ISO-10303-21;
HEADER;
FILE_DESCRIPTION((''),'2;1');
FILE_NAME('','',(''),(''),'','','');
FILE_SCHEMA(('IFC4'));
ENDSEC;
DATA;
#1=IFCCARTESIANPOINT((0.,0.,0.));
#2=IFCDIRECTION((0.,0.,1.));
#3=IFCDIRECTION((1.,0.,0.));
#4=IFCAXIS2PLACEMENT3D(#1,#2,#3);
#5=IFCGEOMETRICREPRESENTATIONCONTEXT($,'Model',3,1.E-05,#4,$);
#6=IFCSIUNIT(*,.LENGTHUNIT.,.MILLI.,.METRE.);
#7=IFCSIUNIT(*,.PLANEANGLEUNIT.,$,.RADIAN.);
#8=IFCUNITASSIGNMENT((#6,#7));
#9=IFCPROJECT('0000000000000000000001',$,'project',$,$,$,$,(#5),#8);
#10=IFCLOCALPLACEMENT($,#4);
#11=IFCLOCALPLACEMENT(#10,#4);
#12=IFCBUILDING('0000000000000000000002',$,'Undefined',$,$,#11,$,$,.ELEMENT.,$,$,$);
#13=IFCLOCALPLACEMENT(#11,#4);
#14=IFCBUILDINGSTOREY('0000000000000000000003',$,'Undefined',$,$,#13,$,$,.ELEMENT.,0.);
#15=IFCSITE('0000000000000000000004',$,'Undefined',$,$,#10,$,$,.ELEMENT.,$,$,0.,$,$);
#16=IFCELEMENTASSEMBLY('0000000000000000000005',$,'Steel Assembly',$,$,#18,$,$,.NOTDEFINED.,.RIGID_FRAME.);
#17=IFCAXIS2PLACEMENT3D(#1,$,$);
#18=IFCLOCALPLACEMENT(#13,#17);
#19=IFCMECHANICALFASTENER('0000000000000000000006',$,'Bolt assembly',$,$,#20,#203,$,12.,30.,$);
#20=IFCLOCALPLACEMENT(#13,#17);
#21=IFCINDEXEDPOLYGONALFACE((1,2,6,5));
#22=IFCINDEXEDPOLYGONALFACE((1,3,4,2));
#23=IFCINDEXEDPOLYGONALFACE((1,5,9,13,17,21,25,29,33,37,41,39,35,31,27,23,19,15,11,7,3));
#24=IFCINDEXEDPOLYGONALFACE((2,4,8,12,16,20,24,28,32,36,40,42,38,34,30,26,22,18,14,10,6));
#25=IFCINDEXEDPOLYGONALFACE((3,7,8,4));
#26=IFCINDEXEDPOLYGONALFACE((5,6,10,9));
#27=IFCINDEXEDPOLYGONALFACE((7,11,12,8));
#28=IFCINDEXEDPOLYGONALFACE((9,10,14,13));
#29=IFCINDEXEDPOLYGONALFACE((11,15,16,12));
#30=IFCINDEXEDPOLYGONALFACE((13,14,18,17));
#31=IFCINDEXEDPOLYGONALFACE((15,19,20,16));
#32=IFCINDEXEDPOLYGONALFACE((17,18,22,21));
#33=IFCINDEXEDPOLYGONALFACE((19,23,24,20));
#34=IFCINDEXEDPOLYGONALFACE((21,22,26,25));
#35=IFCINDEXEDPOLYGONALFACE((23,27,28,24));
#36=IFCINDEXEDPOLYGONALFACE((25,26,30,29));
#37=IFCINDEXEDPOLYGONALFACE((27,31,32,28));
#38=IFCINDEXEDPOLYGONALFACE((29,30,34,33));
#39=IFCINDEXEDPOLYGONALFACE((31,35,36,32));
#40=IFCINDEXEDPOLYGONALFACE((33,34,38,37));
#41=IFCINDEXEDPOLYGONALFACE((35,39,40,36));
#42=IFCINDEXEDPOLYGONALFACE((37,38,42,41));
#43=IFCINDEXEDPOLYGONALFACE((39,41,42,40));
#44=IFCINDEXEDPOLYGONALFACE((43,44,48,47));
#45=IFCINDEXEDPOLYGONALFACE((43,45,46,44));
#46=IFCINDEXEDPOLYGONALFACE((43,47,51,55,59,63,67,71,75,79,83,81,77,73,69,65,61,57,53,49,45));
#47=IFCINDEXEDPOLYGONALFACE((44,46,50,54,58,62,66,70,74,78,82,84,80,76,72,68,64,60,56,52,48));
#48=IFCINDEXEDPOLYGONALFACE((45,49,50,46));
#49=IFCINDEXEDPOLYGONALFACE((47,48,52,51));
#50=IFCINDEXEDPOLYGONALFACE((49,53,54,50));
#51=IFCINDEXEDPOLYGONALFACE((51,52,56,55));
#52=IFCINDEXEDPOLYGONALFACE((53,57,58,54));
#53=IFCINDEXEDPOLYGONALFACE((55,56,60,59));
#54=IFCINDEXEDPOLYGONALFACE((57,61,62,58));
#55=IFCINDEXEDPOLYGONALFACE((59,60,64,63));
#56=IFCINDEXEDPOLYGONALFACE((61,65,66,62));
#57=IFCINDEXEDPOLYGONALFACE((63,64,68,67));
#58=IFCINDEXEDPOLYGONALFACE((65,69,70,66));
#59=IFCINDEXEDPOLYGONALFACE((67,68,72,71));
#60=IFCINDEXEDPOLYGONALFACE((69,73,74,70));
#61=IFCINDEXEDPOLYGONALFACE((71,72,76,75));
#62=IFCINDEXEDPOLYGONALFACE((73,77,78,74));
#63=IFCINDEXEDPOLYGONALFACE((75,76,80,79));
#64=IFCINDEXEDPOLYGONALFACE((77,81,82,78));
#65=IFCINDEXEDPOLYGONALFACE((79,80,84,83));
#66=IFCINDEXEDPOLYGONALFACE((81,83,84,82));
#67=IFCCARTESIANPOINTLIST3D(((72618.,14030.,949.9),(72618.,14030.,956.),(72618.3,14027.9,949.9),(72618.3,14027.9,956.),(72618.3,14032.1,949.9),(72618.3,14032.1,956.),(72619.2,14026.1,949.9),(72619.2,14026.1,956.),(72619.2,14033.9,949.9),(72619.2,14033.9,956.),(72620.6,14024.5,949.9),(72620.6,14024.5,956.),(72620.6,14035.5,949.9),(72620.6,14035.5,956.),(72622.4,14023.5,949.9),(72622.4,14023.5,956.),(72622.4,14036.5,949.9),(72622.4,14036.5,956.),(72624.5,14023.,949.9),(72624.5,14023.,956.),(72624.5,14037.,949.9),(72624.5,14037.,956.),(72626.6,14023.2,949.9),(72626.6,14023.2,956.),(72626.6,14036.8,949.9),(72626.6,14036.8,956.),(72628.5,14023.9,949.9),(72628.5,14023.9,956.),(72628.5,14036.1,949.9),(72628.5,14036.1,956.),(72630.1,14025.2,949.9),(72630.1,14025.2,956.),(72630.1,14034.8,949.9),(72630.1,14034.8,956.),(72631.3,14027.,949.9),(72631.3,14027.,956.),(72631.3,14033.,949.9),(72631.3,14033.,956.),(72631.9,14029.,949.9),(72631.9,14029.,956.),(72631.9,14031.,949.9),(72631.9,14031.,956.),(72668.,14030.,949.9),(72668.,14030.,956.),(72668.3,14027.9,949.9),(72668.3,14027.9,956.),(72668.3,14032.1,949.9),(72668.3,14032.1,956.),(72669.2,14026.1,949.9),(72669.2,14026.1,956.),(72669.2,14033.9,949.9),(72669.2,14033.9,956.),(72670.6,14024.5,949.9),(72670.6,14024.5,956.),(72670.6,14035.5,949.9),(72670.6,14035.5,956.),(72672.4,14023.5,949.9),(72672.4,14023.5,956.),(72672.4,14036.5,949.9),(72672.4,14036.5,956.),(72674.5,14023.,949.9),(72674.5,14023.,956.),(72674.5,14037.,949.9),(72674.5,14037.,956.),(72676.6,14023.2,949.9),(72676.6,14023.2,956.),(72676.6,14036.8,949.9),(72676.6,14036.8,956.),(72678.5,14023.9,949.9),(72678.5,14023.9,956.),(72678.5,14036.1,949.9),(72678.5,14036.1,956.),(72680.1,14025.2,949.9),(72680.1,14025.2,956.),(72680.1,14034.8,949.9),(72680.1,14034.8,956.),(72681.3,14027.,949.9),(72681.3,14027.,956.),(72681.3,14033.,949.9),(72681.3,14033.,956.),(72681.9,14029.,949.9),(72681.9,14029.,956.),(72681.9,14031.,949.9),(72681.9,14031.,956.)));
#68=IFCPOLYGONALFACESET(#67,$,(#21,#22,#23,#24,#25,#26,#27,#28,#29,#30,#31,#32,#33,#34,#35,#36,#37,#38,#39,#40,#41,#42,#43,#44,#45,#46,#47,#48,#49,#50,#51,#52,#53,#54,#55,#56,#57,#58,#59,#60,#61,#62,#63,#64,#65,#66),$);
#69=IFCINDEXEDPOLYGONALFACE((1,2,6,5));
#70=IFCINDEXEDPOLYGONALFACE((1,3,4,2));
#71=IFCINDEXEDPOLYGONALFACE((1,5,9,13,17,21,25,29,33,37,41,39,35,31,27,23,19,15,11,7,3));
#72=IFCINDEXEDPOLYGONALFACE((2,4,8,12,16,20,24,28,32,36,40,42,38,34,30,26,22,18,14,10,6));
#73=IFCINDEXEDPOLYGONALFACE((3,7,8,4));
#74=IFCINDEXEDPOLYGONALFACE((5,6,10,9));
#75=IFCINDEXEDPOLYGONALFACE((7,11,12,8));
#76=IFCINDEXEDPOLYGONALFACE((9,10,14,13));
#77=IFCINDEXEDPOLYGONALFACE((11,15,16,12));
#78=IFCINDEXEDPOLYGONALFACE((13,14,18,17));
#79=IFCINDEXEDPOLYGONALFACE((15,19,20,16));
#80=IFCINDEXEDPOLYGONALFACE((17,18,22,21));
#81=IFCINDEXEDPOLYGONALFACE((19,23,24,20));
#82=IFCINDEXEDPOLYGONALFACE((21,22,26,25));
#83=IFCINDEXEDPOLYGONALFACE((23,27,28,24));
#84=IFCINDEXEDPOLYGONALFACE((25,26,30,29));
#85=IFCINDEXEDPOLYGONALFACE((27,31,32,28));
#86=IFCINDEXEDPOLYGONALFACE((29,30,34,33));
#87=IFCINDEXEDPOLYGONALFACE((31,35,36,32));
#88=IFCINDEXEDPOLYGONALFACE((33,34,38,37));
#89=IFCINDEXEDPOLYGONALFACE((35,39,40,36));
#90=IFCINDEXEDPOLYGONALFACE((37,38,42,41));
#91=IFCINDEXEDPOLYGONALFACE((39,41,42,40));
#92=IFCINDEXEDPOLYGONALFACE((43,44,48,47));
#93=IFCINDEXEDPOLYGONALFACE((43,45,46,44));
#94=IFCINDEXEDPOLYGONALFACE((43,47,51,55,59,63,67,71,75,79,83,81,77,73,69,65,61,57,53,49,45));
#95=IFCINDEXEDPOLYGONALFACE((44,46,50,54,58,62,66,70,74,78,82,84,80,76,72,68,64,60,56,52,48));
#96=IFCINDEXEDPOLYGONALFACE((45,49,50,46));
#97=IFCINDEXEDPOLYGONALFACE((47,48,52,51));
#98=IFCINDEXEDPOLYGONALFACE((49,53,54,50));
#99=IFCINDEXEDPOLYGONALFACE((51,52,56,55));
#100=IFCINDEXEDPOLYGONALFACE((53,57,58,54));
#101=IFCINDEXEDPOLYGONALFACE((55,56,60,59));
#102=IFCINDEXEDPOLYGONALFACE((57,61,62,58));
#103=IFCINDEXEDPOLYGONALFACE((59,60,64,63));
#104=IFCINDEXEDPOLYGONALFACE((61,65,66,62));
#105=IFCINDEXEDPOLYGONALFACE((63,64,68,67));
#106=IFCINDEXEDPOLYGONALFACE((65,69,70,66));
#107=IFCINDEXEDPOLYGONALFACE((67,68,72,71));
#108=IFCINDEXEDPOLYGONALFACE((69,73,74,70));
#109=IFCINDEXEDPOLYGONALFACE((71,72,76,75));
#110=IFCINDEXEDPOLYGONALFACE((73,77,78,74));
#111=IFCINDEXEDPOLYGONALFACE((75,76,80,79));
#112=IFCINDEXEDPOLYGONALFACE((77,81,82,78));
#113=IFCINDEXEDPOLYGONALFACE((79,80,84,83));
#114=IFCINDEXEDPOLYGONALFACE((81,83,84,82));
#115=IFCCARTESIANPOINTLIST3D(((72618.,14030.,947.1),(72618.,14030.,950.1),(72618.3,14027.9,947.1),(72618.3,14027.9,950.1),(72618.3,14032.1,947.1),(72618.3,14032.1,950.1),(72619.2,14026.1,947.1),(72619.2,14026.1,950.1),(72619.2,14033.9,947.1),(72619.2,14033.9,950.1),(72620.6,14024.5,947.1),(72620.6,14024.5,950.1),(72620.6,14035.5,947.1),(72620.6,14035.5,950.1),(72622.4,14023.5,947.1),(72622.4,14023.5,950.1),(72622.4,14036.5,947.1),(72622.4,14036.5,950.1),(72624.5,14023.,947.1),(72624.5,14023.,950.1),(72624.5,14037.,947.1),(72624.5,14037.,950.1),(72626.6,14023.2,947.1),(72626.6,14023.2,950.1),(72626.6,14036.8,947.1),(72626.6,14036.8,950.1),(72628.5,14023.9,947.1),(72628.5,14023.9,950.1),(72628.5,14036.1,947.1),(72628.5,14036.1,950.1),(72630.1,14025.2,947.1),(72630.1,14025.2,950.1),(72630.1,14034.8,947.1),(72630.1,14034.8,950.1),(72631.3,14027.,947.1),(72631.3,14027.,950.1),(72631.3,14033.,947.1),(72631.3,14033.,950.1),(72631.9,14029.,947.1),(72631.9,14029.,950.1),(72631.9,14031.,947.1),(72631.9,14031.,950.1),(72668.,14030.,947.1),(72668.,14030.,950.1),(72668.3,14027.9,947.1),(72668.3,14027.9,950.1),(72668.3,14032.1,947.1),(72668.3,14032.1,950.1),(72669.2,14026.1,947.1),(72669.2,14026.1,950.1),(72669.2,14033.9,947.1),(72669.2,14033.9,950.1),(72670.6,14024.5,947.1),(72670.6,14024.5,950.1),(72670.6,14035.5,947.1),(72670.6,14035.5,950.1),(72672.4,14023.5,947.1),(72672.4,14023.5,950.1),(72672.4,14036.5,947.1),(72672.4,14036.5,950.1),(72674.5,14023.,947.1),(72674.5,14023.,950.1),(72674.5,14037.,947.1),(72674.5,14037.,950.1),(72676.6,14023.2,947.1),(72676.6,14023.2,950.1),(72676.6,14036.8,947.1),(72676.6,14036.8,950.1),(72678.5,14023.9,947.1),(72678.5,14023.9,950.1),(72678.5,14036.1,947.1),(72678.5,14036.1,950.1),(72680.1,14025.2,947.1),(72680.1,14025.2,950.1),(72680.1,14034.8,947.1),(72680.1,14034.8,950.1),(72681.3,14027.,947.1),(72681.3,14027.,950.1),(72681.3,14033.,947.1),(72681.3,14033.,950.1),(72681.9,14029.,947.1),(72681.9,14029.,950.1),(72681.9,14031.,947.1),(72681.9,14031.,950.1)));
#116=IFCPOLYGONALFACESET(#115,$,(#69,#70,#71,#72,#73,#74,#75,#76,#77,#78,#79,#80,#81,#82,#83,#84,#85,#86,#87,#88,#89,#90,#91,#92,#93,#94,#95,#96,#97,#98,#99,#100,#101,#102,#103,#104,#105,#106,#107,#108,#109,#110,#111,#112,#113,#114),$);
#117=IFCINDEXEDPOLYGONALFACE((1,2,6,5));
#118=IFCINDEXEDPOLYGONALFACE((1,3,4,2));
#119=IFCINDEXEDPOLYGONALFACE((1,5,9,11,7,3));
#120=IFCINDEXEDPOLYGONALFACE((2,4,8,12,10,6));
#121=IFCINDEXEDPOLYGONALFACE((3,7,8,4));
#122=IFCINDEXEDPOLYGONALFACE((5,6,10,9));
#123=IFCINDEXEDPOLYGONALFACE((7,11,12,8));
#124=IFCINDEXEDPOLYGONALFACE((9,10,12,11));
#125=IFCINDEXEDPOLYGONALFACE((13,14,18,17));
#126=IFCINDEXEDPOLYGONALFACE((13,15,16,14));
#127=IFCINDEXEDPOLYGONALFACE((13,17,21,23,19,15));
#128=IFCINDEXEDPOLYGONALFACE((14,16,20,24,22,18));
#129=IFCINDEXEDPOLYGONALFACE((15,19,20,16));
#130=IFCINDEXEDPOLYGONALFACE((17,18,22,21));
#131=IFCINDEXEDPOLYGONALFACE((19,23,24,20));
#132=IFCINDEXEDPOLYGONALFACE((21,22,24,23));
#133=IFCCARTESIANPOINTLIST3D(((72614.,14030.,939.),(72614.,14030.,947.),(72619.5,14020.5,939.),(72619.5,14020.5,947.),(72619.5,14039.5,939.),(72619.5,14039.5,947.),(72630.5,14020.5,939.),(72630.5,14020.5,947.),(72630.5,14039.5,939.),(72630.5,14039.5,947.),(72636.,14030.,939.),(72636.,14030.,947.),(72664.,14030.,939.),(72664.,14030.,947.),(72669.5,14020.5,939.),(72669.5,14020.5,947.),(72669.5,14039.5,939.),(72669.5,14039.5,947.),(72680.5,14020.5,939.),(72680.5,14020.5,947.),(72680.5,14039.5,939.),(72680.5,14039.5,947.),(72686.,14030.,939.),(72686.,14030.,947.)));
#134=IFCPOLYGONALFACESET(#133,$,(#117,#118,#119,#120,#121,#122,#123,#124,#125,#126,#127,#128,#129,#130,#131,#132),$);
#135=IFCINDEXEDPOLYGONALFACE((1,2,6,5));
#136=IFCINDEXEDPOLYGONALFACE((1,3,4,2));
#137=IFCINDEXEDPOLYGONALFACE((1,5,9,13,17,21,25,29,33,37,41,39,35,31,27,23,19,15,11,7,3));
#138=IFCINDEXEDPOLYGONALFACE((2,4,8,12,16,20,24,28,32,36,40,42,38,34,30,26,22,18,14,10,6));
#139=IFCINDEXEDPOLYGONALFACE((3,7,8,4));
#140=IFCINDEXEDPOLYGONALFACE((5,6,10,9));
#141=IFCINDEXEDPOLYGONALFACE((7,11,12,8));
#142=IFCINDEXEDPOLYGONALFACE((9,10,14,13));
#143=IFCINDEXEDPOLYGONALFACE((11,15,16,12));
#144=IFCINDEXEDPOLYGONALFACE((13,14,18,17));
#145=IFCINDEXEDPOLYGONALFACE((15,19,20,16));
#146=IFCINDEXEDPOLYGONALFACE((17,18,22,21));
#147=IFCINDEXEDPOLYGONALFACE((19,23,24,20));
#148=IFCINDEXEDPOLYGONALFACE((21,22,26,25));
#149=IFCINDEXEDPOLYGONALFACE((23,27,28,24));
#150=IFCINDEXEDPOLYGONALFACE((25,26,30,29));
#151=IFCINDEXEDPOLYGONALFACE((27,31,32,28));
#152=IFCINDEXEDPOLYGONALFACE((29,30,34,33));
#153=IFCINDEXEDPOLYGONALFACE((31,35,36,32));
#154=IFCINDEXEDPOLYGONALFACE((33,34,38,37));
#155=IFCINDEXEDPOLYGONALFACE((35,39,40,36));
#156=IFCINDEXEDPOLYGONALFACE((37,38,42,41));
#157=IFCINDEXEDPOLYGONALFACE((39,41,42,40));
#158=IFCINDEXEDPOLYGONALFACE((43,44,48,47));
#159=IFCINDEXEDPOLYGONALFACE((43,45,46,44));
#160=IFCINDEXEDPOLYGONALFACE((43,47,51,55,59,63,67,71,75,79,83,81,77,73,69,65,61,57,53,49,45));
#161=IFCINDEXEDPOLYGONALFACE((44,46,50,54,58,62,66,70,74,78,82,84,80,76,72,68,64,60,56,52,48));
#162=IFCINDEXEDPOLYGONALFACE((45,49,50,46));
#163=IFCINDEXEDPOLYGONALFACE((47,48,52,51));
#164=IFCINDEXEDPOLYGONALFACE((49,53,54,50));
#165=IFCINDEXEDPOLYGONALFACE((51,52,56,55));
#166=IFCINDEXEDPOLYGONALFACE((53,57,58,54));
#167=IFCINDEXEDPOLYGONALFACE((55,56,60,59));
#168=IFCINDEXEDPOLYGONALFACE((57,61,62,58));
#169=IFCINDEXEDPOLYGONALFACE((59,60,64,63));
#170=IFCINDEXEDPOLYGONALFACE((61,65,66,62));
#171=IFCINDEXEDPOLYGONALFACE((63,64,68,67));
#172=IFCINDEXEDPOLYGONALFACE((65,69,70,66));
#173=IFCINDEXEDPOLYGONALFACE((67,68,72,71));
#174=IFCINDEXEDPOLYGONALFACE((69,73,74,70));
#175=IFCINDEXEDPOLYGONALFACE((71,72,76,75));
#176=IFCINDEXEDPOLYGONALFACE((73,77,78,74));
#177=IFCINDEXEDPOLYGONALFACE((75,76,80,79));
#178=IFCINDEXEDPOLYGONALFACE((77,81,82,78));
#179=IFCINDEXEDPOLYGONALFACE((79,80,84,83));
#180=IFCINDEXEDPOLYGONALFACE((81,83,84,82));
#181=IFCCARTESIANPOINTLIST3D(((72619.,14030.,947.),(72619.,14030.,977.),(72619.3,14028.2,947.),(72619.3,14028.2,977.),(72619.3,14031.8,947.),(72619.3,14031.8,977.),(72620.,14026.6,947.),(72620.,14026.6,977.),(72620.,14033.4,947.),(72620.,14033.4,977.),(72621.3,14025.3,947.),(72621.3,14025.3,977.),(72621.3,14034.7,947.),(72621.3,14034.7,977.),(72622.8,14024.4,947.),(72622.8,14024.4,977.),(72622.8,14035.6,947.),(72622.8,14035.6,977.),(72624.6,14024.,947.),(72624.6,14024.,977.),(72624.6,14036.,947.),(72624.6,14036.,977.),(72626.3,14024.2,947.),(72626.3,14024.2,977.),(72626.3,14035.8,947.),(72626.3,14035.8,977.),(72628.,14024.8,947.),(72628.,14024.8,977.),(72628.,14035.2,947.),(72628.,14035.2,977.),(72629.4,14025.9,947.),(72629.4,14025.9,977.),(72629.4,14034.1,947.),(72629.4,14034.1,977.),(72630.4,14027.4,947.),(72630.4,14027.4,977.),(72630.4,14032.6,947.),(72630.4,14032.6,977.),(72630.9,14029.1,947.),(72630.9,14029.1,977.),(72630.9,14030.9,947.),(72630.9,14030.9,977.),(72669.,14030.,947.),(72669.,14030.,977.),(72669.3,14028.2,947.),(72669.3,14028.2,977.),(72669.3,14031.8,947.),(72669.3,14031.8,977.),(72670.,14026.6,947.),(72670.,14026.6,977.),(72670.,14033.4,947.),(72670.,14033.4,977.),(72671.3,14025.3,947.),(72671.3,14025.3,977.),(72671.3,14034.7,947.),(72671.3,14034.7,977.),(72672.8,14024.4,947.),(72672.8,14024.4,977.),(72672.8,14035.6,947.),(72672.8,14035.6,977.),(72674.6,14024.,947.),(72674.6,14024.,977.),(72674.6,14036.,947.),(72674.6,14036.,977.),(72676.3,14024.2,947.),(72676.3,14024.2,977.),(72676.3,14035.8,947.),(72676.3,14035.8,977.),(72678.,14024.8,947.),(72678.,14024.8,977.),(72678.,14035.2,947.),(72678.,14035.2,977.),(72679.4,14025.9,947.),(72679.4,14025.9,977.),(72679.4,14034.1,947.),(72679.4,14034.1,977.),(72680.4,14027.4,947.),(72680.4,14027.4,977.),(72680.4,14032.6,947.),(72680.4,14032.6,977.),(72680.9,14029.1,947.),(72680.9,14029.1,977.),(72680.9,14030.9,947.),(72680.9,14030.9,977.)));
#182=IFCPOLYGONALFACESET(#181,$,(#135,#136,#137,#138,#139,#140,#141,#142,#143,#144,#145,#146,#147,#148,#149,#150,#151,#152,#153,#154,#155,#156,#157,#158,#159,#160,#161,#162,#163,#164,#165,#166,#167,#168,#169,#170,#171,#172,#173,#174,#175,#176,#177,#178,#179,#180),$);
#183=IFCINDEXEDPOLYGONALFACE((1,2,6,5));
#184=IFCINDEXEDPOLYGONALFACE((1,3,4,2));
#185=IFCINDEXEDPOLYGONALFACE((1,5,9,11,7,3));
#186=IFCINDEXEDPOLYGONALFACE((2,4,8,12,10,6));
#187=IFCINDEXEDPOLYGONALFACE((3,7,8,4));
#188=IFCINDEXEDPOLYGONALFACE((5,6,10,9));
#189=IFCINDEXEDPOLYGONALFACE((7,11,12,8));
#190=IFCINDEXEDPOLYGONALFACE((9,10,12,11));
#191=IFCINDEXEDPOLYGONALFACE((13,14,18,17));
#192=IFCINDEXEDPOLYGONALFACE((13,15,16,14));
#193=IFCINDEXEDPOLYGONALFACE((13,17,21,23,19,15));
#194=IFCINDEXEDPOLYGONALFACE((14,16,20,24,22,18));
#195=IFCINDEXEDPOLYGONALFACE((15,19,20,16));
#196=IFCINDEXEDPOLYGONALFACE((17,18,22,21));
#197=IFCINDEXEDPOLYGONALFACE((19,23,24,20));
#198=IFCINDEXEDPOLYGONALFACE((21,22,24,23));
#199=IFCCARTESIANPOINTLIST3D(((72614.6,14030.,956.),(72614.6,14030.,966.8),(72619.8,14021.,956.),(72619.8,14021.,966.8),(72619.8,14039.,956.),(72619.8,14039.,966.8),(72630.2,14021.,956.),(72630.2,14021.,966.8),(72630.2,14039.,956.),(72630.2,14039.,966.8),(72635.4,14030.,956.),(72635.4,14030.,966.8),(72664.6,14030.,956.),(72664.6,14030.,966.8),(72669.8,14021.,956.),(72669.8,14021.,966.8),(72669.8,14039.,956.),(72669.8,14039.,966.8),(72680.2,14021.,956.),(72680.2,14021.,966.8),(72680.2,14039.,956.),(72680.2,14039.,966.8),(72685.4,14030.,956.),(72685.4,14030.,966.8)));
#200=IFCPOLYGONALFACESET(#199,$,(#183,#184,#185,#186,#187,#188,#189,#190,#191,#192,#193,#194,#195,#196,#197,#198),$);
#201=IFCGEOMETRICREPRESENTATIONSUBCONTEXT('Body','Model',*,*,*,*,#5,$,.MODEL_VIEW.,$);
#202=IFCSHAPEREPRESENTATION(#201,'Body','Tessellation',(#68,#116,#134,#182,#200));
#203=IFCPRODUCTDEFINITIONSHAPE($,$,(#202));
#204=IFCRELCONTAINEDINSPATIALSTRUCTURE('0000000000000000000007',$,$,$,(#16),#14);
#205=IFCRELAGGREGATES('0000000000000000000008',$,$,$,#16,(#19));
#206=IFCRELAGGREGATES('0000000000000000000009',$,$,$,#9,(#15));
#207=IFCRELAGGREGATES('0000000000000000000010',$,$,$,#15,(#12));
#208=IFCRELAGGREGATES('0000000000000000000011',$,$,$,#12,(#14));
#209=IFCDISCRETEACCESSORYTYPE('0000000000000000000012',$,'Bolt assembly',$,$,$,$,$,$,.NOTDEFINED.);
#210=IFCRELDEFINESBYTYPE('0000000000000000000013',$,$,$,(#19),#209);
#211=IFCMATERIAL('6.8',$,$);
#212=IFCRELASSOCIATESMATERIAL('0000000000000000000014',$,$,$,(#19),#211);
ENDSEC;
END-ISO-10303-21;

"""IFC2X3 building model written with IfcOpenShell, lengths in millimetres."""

from ifc_helpers import new_model, si_unit, frame, origin_with_axes, origin_2d_with_axis, place, context, subcontext, project, spatial, polyline, circle, outline, extrude, source, transform, mapped, material, type_object, element, aggregate, save


model = new_model("IFC2X3")

# Units and contexts
model_context = context("Model", 3, precision=1e-05, world=origin_with_axes())
body_context = subcontext(model_context, "Body", "Model", "MODEL_VIEW")
ifc_project = project(units=[si_unit("LENGTHUNIT", "METRE", prefix="MILLI"), si_unit("PLANEANGLEUNIT", "RADIAN")], contexts=[model_context])

# Site, building, storey
site_placement = place(None, origin_with_axes())
site = spatial("IfcSite", under=ifc_project, at=site_placement, Name="Undefined", CompositionType="ELEMENT", RefElevation=0.0)
building_placement = place(site_placement, origin_with_axes())
building = spatial("IfcBuilding", under=site, at=building_placement, Name="Undefined", CompositionType="ELEMENT")
storey_placement = place(building_placement, origin_with_axes())
storey = spatial("IfcBuildingStorey", under=building, at=storey_placement, Name="Undefined", CompositionType="ELEMENT", Elevation=0.0)

# Element assembly
assembly_1_placement = place(storey_placement, origin_with_axes())
assembly_1 = element("IfcElementAssembly", 1, at=assembly_1_placement, inside=storey, Name="Steel Assembly", AssemblyPlace="NOTDEFINED", PredefinedType="RIGID_FRAME")

# Shared definitions
ifc_material_1 = material(Name="6.8")
discrete_accessory_type_1 = type_object("IfcDiscreteAccessoryType", Name="Bolt assembly")

# Mechanical fastener
shared_shape_1 = source(origin_with_axes(), body_context, "Body", "SweptSolid", [
    extrude(circle(Radius=7.0, at=origin_2d_with_axis()), frame((0.0, -6.1, 0.0), z_axis=(0.0, 1.0, 0.0), x_axis=(1.0, 0.0, 0.0)), (0.0, 0.0, 1.0), 6.1),
    extrude(circle(Radius=7.0, at=origin_2d_with_axis()), frame((0.0, -8.9, 0.0), z_axis=(0.0, 1.0, 0.0), x_axis=(1.0, 0.0, 0.0)), (0.0, 0.0, 1.0), 3.0),
    extrude(outline(polyline([(11.0, 0.0), (5.5, 9.5), (-5.5, 9.5), (-11.0, 0.0), (-5.5, -9.5), (5.5, -9.5), (11.0, 0.0)])), frame((0.0, -17.0, 0.0), z_axis=(0.0, 1.0, 0.0), x_axis=(1.0, 0.0, 0.0)), (0.0, 0.0, 1.0), 8.0),
    extrude(circle(Radius=6.0, at=origin_2d_with_axis()), frame((0.0, -9.0, 0.0), z_axis=(0.0, 1.0, 0.0), x_axis=(1.0, 0.0, 0.0)), (0.0, 0.0, 1.0), 30.0),
    extrude(outline(polyline([(10.4, 0.0), (5.2, 9.0), (-5.2, 9.0), (-10.4, 0.0), (-5.2, -9.0), (5.2, -9.0), (10.4, 0.0)])), frame((0.0, 0.0, 0.0), z_axis=(0.0, 1.0, 0.0), x_axis=(1.0, 0.0, 0.0)), (0.0, 0.0, 1.0), 10.8),
])
mechanical_fastener_1_placement = place(assembly_1_placement, frame((72675.0, 14030.0, 956.0), z_axis=(0.0, 1.0, 0.0), x_axis=(-1.0, 0.0, 0.0)))
mechanical_fastener_1 = element("IfcMechanicalFastener", 2, at=mechanical_fastener_1_placement, type_object=discrete_accessory_type_1, material=ifc_material_1, Name="Bolt assembly", NominalDiameter=12.0, NominalLength=30.0, context=body_context, shape_type="MappedRepresentation", body=[
    mapped(shared_shape_1, transform((0.0, 0.0, 0.0))),
    mapped(shared_shape_1, transform((50.0, 0.0, 0.0))),
])
aggregate(assembly_1, [mechanical_fastener_1])

save(model, "model.ifc")
